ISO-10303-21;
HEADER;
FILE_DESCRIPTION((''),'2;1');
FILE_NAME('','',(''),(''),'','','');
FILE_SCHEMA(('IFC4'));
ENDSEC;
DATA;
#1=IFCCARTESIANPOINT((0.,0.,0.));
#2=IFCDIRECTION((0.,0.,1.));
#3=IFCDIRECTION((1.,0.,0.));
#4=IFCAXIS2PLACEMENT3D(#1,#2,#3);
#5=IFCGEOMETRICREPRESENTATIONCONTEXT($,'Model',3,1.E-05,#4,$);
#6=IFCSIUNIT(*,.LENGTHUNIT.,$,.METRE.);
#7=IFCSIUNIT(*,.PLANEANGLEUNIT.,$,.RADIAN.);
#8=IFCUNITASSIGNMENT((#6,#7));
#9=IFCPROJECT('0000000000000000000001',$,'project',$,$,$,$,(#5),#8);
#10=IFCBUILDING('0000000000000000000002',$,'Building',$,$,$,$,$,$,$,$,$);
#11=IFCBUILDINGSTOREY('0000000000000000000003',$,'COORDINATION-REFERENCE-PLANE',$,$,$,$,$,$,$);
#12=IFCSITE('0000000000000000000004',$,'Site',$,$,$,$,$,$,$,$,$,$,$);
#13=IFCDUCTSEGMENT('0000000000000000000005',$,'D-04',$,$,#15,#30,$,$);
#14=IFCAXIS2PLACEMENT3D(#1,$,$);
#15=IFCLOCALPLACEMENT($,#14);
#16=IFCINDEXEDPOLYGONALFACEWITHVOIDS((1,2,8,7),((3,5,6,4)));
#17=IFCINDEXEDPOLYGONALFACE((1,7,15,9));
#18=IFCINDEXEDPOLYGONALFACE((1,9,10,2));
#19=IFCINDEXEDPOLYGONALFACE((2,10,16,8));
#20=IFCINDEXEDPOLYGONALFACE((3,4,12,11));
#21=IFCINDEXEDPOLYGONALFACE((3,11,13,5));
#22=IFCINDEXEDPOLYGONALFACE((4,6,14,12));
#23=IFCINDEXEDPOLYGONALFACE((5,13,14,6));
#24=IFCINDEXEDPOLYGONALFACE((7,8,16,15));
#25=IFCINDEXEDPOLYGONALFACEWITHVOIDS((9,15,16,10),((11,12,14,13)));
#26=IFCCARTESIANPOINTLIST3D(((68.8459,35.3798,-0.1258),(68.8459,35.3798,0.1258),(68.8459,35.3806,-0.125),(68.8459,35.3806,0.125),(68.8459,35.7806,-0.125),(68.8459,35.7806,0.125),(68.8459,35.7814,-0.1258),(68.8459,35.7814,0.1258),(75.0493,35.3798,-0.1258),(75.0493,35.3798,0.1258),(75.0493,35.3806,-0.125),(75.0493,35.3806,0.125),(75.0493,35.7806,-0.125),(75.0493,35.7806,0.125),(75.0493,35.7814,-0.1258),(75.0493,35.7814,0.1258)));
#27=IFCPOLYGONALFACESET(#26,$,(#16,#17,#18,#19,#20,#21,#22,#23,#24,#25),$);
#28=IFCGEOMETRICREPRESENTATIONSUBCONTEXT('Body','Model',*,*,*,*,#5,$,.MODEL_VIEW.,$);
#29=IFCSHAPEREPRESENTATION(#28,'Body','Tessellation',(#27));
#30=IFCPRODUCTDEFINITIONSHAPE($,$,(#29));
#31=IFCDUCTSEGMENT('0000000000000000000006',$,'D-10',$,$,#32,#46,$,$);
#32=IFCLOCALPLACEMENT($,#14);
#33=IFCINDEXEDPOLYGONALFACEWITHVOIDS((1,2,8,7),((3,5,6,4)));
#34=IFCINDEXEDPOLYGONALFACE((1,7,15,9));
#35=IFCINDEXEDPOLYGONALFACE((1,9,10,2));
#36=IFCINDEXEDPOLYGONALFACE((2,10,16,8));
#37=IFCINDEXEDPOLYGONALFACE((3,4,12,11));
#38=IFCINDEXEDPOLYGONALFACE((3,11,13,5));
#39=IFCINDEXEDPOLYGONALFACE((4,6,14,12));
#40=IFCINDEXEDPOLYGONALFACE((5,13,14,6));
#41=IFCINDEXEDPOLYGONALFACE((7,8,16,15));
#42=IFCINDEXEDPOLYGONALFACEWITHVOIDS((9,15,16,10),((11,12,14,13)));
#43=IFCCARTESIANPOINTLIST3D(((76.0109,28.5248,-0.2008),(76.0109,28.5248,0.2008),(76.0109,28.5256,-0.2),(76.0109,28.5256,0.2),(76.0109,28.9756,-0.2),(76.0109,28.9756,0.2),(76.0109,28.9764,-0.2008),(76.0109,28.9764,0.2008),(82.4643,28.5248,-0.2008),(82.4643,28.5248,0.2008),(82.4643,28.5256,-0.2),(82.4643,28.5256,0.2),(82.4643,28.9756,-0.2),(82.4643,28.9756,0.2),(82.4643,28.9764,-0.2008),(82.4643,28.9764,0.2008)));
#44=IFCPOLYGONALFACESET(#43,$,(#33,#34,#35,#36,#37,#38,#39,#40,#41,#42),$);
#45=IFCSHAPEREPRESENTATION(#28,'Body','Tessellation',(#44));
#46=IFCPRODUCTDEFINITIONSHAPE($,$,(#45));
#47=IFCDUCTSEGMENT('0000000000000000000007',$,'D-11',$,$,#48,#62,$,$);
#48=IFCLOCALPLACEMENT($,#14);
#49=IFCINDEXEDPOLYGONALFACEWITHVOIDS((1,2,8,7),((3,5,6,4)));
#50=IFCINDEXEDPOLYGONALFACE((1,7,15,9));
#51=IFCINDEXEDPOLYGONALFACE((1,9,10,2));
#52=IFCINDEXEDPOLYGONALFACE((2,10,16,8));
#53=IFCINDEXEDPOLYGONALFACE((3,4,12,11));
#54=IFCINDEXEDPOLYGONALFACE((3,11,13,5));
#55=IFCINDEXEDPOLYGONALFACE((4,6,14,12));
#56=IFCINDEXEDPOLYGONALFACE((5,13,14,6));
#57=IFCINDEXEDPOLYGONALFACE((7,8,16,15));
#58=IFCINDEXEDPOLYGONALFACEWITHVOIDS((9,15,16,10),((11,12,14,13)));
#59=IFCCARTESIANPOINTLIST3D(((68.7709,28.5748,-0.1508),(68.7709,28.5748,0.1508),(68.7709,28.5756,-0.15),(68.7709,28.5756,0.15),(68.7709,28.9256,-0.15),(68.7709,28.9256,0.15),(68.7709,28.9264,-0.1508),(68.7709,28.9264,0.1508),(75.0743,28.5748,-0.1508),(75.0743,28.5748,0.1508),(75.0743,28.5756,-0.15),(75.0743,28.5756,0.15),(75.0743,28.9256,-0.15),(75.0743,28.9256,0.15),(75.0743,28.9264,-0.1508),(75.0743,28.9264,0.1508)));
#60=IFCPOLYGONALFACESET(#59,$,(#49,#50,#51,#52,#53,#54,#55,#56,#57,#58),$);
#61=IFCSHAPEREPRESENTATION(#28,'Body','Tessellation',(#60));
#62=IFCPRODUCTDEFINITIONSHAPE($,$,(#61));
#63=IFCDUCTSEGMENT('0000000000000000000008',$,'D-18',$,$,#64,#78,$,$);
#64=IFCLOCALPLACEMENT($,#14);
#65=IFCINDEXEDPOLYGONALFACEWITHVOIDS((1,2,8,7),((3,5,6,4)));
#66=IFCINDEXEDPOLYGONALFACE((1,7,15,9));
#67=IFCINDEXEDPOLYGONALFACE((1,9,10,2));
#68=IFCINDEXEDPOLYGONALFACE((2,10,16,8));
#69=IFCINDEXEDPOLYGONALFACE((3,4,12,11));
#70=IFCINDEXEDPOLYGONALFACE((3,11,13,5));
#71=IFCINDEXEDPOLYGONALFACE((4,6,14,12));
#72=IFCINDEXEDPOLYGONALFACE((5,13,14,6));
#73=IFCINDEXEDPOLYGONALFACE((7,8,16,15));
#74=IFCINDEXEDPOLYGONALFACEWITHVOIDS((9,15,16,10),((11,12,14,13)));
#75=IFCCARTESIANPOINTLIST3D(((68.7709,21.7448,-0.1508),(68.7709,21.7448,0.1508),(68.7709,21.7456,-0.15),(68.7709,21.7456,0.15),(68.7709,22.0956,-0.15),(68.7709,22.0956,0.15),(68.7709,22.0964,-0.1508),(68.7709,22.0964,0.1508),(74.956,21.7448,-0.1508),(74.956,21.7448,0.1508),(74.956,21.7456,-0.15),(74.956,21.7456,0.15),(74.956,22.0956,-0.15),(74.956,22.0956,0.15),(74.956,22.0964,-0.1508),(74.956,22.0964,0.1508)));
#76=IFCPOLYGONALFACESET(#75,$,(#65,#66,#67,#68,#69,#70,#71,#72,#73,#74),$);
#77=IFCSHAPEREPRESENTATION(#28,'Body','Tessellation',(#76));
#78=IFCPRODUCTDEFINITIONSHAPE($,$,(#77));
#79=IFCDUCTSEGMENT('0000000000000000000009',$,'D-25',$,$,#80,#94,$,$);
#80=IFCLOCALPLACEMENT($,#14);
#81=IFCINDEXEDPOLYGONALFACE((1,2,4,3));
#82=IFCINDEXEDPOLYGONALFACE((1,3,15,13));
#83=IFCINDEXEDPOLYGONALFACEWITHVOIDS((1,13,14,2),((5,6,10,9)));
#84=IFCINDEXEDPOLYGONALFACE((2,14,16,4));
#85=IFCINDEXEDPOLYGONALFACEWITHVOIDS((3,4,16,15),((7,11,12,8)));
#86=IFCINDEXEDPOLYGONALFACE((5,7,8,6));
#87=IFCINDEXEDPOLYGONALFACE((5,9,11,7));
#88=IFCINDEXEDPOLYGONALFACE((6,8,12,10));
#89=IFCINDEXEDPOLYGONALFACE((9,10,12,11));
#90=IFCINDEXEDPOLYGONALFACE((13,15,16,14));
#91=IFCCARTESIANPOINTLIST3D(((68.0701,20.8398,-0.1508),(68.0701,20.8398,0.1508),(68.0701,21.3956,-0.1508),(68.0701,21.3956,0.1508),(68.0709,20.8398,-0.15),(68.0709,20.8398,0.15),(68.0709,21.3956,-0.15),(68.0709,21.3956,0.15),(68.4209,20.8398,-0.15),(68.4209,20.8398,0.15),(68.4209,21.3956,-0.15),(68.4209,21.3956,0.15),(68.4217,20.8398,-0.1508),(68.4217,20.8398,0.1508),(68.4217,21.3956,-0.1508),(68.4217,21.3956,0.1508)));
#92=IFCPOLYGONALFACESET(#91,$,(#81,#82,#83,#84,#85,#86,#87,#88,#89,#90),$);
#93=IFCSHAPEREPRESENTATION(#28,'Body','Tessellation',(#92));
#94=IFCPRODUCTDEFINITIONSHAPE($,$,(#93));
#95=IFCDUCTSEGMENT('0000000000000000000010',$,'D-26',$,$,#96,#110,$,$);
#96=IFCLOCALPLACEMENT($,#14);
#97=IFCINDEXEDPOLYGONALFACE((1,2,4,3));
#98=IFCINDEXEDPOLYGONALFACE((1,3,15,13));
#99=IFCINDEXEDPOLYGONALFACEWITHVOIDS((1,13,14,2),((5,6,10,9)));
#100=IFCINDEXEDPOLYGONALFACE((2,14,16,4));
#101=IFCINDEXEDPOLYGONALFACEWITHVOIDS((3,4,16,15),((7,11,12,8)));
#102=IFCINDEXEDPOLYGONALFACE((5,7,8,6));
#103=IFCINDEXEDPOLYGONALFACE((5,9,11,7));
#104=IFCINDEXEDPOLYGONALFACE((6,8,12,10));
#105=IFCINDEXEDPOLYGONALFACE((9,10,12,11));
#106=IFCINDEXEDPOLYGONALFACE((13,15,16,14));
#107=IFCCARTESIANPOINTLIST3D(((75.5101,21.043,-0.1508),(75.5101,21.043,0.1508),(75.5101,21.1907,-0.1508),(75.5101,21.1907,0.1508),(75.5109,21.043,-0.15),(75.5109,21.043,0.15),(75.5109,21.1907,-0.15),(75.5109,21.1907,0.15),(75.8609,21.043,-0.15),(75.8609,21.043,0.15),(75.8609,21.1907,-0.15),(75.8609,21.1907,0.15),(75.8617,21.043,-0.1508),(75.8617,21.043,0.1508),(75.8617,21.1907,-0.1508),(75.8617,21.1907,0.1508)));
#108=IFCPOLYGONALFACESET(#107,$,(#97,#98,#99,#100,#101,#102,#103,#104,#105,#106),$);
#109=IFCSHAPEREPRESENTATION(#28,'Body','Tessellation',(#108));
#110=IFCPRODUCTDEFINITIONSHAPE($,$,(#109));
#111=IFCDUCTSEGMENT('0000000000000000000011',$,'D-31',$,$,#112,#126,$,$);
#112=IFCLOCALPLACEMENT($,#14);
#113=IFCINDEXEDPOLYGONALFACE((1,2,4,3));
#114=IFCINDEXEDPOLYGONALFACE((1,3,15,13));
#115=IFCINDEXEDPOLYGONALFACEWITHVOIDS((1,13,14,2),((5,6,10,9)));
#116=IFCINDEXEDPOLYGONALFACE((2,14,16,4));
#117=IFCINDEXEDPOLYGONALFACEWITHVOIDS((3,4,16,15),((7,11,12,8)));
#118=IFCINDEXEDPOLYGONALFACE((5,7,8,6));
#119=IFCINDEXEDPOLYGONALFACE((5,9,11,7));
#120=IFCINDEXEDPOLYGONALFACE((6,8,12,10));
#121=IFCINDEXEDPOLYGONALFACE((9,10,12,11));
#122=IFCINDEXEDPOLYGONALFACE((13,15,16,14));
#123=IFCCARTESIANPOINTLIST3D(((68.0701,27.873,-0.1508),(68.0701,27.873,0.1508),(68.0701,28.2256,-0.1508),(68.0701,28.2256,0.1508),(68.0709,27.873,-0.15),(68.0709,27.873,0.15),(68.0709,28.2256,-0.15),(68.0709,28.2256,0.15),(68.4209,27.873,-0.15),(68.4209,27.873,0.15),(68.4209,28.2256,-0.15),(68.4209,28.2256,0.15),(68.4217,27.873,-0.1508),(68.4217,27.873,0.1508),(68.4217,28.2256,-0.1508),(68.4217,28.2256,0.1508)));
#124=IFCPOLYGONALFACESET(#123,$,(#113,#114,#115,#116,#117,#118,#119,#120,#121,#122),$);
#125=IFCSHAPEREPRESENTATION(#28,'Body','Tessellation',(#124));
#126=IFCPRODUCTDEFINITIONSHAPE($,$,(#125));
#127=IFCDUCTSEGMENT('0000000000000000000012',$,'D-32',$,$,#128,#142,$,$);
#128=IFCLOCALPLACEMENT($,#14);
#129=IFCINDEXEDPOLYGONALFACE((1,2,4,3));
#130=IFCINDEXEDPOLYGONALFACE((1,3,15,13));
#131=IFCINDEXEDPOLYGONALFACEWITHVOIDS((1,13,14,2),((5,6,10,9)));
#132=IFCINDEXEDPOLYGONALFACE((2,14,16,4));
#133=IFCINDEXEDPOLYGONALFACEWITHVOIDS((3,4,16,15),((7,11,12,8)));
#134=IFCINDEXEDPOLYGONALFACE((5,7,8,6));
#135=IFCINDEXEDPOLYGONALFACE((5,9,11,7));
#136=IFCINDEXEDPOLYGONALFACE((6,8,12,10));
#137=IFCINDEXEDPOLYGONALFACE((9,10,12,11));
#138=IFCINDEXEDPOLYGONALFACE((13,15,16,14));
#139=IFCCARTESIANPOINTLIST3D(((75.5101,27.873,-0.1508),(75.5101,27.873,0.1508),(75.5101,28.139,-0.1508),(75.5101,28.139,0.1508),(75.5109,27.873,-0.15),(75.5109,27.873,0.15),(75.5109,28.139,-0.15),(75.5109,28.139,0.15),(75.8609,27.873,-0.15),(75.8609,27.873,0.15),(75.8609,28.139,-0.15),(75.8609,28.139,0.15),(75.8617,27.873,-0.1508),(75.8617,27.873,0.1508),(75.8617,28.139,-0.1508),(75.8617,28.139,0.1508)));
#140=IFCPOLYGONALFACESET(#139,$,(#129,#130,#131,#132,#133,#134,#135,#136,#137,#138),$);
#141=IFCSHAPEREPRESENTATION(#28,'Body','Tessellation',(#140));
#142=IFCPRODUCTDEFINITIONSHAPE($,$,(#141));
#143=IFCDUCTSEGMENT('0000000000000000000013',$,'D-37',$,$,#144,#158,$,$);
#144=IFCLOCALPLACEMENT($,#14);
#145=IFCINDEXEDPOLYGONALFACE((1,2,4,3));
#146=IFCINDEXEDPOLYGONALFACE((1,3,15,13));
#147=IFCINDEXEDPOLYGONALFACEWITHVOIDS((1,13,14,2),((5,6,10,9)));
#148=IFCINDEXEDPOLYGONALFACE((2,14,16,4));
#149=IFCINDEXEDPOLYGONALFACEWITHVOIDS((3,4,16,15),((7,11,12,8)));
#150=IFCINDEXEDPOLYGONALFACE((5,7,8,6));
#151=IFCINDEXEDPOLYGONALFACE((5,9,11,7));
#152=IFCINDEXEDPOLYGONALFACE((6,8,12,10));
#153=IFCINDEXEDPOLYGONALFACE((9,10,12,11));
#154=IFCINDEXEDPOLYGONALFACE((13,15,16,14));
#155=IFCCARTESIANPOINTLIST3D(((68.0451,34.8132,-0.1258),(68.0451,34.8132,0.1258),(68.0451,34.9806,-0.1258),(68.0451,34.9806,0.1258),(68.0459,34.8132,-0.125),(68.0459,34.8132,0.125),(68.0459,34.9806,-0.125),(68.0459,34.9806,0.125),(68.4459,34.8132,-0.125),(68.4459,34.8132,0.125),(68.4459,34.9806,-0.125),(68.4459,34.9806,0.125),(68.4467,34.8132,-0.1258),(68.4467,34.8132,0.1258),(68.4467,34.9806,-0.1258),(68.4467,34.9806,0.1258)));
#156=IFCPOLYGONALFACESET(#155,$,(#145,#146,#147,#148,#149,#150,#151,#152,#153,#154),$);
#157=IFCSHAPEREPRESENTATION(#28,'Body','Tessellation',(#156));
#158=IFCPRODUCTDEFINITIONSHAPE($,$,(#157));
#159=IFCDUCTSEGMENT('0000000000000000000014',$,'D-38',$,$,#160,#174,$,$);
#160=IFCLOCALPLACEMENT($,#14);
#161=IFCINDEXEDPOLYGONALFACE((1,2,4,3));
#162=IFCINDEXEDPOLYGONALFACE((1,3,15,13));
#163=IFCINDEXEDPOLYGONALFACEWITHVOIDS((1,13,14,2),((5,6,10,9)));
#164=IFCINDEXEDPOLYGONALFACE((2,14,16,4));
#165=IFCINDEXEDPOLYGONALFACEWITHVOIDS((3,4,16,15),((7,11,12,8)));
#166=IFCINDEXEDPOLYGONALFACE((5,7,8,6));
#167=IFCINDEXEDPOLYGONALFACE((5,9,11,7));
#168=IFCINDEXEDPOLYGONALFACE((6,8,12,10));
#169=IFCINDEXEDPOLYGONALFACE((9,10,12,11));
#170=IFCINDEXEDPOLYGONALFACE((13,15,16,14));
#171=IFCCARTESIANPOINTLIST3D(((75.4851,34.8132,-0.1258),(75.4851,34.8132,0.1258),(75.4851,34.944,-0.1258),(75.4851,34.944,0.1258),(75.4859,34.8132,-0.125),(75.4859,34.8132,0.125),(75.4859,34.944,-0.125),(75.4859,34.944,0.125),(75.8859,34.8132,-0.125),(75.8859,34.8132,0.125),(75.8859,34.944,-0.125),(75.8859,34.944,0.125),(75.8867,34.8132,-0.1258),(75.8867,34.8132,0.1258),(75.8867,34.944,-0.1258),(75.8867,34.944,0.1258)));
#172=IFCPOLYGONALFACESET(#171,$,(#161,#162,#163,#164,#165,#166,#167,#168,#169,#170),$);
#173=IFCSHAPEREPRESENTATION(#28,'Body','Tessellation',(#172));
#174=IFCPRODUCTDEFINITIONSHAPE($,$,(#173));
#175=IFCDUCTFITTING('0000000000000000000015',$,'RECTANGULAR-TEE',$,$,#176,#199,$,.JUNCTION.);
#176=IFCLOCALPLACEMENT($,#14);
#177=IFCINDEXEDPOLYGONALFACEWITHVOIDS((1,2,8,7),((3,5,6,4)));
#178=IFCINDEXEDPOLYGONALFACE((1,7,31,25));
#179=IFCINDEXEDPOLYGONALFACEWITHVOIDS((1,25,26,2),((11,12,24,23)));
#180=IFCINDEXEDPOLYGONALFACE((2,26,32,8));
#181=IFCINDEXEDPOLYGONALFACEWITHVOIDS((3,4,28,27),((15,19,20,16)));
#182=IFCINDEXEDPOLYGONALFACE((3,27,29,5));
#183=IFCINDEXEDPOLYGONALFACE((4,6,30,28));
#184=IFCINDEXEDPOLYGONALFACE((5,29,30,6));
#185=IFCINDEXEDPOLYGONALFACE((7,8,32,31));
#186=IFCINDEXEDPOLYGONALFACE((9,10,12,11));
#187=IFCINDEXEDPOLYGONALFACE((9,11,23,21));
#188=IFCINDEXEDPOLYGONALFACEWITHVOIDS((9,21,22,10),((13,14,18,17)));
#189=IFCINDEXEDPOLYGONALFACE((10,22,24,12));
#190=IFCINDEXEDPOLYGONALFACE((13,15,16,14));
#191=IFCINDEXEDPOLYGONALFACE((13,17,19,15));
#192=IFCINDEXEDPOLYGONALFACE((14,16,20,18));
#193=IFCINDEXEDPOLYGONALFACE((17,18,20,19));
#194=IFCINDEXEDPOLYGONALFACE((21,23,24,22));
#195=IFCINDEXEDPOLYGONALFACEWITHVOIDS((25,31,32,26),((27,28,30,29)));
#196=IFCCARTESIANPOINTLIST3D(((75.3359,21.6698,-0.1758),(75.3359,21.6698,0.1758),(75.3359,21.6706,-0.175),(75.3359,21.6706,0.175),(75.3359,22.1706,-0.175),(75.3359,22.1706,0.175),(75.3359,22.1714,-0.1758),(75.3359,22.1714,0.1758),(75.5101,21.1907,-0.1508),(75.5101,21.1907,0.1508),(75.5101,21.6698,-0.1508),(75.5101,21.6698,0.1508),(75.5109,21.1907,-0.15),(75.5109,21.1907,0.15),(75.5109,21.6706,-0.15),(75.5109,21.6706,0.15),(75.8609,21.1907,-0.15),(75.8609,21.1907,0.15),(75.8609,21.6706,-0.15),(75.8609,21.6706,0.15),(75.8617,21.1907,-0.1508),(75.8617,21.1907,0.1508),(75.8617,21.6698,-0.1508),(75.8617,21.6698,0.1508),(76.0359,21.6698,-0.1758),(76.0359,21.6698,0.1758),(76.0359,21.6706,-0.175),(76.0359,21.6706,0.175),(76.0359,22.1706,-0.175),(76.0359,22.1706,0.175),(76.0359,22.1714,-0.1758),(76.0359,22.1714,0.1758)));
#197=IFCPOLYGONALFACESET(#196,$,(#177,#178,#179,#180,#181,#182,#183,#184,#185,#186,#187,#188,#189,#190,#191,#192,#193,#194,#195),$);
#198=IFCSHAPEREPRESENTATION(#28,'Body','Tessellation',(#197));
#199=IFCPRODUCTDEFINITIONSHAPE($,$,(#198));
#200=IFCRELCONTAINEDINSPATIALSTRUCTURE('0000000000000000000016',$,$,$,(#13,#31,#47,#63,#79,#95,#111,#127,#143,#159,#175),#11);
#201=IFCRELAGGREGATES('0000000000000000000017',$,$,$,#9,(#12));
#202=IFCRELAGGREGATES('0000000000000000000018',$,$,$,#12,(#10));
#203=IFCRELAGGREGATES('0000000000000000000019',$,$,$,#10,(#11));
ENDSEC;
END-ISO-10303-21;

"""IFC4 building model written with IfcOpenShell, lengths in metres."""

from ifc_helpers import new_model, si_unit, frame, origin, origin_with_axes, place, context, subcontext, project, spatial, rectangle, hollow_rectangle, extrude, boolean, element, save


model = new_model("IFC4")

# Units and contexts
model_context = context("Model", 3, precision=1e-05, world=origin_with_axes())
body_context_1 = subcontext(model_context, "Body", "Model", "MODEL_VIEW")
ifc_project = project(units=[si_unit("LENGTHUNIT", "METRE"), si_unit("PLANEANGLEUNIT", "RADIAN")], contexts=[model_context])

# Site, building, storey
site = spatial("IfcSite", under=ifc_project, Name="Site")
building = spatial("IfcBuilding", under=site, Name="Building")
storey = spatial("IfcBuildingStorey", under=building, Name="COORDINATION-REFERENCE-PLANE")

# Duct segments
duct_segment_1_placement = place(None, frame((68.8459, 35.5806, 0.0), z_axis=(1.0, 0.0, 0.0), x_axis=(0.0, 1.0, 0.0)))
element("IfcDuctSegment", 1, at=duct_segment_1_placement, inside=storey, Name="D-04", context=body_context_1, shape_type="SweptSolid", body=[
    extrude(hollow_rectangle(XDim=0.4016, YDim=0.2516, WallThickness=0.0008), origin(), (0.0, 0.0, 1.0), 6.2034),
])
duct_segment_2_placement = place(None, frame((76.0109, 28.7506, 0.0), z_axis=(1.0, 0.0, 0.0), x_axis=(0.0, 1.0, 0.0)))
element("IfcDuctSegment", 2, at=duct_segment_2_placement, inside=storey, Name="D-10", context=body_context_1, shape_type="SweptSolid", body=[
    extrude(hollow_rectangle(XDim=0.4516, YDim=0.4016, WallThickness=0.0008), origin(), (0.0, 0.0, 1.0), 6.4534),
])
duct_segment_3_placement = place(None, frame((68.7709, 28.7506, 0.0), z_axis=(1.0, 0.0, 0.0), x_axis=(0.0, 1.0, 0.0)))
element("IfcDuctSegment", 3, at=duct_segment_3_placement, inside=storey, Name="D-11", context=body_context_1, shape_type="SweptSolid", body=[
    extrude(hollow_rectangle(XDim=0.3516, YDim=0.3016, WallThickness=0.0008), origin(), (0.0, 0.0, 1.0), 6.3034),
])
duct_segment_4_placement = place(None, frame((68.7709, 21.9206, 0.0), z_axis=(1.0, 0.0, 0.0), x_axis=(0.0, 1.0, 0.0)))
element("IfcDuctSegment", 4, at=duct_segment_4_placement, inside=storey, Name="D-18", context=body_context_1, shape_type="SweptSolid", body=[
    extrude(hollow_rectangle(XDim=0.3516, YDim=0.3016, WallThickness=0.0008), origin(), (0.0, 0.0, 1.0), 6.1851),
])
duct_segment_5_placement = place(None, frame((68.2459, 20.8398, 0.0), z_axis=(0.0, 1.0, 0.0), x_axis=(1.0, 0.0, 0.0)))
element("IfcDuctSegment", 5, at=duct_segment_5_placement, inside=storey, Name="D-25", context=body_context_1, shape_type="SweptSolid", body=[
    extrude(hollow_rectangle(XDim=0.3516, YDim=0.3016, WallThickness=0.0008), origin(), (0.0, 0.0, 1.0), 0.5558),
])
duct_segment_6_placement = place(None, frame((75.6859, 21.043, 0.0), z_axis=(0.0, 1.0, 0.0), x_axis=(1.0, 0.0, 0.0)))
element("IfcDuctSegment", 6, at=duct_segment_6_placement, inside=storey, Name="D-26", context=body_context_1, shape_type="SweptSolid", body=[
    extrude(hollow_rectangle(XDim=0.3516, YDim=0.3016, WallThickness=0.0008), origin(), (0.0, 0.0, 1.0), 0.1477),
])
duct_segment_7_placement = place(None, frame((68.2459, 27.873, 0.0), z_axis=(0.0, 1.0, 0.0), x_axis=(1.0, 0.0, 0.0)))
element("IfcDuctSegment", 7, at=duct_segment_7_placement, inside=storey, Name="D-31", context=body_context_1, shape_type="SweptSolid", body=[
    extrude(hollow_rectangle(XDim=0.3516, YDim=0.3016, WallThickness=0.0008), origin(), (0.0, 0.0, 1.0), 0.3526),
])
duct_segment_8_placement = place(None, frame((75.6859, 27.873, 0.0), z_axis=(0.0, 1.0, 0.0), x_axis=(1.0, 0.0, 0.0)))
element("IfcDuctSegment", 8, at=duct_segment_8_placement, inside=storey, Name="D-32", context=body_context_1, shape_type="SweptSolid", body=[
    extrude(hollow_rectangle(XDim=0.3516, YDim=0.3016, WallThickness=0.0008), origin(), (0.0, 0.0, 1.0), 0.266),
])
duct_segment_9_placement = place(None, frame((68.2459, 34.8132, 0.0), z_axis=(0.0, 1.0, 0.0), x_axis=(1.0, 0.0, 0.0)))
element("IfcDuctSegment", 9, at=duct_segment_9_placement, inside=storey, Name="D-37", context=body_context_1, shape_type="SweptSolid", body=[
    extrude(hollow_rectangle(XDim=0.4016, YDim=0.2516, WallThickness=0.0008), origin(), (0.0, 0.0, 1.0), 0.1673),
])
duct_segment_10_placement = place(None, frame((75.6859, 34.8132, 0.0), z_axis=(0.0, 1.0, 0.0), x_axis=(1.0, 0.0, 0.0)))
element("IfcDuctSegment", 10, at=duct_segment_10_placement, inside=storey, Name="D-38", context=body_context_1, shape_type="SweptSolid", body=[
    extrude(hollow_rectangle(XDim=0.4016, YDim=0.2516, WallThickness=0.0008), origin(), (0.0, 0.0, 1.0), 0.1307),
])

# Duct fitting
duct_fitting_1_placement = place(None, frame((75.6859, 21.9206, 0.0), z_axis=(-1.0, 0.0, 0.0), x_axis=(0.0, -1.0, 0.0)))
solid_1 = boolean("UNION", extrude(rectangle(XDim=0.5, YDim=0.35), frame((0.0, 0.0, -0.35), z_axis=(0.0, 0.0, 1.0), x_axis=(1.0, 0.0, 0.0)), (0.0, 0.0, 1.0), 0.7), extrude(rectangle(XDim=0.35, YDim=0.3), frame((0.0, 0.0, 0.0), z_axis=(1.0, 0.0, 0.0), x_axis=(0.0, 0.0, -1.0)), (0.0, 0.0, 1.0), 0.7299))
element("IfcDuctFitting", 11, at=duct_fitting_1_placement, inside=storey, Name="RECTANGULAR-TEE", PredefinedType="JUNCTION", context=body_context_1, shape_type="CSG", body=[
    boolean("DIFFERENCE", boolean("UNION", extrude(rectangle(XDim=0.5016, YDim=0.3516), frame((0.0, 0.0, -0.35), z_axis=(0.0, 0.0, 1.0), x_axis=(1.0, 0.0, 0.0)), (0.0, 0.0, 1.0), 0.7), extrude(rectangle(XDim=0.3516, YDim=0.3016), frame((0.0, 0.0, 0.0), z_axis=(1.0, 0.0, 0.0), x_axis=(0.0, 0.0, -1.0)), (0.0, 0.0, 1.0), 0.7299)), solid_1),
])

save(model, "model.ifc")
